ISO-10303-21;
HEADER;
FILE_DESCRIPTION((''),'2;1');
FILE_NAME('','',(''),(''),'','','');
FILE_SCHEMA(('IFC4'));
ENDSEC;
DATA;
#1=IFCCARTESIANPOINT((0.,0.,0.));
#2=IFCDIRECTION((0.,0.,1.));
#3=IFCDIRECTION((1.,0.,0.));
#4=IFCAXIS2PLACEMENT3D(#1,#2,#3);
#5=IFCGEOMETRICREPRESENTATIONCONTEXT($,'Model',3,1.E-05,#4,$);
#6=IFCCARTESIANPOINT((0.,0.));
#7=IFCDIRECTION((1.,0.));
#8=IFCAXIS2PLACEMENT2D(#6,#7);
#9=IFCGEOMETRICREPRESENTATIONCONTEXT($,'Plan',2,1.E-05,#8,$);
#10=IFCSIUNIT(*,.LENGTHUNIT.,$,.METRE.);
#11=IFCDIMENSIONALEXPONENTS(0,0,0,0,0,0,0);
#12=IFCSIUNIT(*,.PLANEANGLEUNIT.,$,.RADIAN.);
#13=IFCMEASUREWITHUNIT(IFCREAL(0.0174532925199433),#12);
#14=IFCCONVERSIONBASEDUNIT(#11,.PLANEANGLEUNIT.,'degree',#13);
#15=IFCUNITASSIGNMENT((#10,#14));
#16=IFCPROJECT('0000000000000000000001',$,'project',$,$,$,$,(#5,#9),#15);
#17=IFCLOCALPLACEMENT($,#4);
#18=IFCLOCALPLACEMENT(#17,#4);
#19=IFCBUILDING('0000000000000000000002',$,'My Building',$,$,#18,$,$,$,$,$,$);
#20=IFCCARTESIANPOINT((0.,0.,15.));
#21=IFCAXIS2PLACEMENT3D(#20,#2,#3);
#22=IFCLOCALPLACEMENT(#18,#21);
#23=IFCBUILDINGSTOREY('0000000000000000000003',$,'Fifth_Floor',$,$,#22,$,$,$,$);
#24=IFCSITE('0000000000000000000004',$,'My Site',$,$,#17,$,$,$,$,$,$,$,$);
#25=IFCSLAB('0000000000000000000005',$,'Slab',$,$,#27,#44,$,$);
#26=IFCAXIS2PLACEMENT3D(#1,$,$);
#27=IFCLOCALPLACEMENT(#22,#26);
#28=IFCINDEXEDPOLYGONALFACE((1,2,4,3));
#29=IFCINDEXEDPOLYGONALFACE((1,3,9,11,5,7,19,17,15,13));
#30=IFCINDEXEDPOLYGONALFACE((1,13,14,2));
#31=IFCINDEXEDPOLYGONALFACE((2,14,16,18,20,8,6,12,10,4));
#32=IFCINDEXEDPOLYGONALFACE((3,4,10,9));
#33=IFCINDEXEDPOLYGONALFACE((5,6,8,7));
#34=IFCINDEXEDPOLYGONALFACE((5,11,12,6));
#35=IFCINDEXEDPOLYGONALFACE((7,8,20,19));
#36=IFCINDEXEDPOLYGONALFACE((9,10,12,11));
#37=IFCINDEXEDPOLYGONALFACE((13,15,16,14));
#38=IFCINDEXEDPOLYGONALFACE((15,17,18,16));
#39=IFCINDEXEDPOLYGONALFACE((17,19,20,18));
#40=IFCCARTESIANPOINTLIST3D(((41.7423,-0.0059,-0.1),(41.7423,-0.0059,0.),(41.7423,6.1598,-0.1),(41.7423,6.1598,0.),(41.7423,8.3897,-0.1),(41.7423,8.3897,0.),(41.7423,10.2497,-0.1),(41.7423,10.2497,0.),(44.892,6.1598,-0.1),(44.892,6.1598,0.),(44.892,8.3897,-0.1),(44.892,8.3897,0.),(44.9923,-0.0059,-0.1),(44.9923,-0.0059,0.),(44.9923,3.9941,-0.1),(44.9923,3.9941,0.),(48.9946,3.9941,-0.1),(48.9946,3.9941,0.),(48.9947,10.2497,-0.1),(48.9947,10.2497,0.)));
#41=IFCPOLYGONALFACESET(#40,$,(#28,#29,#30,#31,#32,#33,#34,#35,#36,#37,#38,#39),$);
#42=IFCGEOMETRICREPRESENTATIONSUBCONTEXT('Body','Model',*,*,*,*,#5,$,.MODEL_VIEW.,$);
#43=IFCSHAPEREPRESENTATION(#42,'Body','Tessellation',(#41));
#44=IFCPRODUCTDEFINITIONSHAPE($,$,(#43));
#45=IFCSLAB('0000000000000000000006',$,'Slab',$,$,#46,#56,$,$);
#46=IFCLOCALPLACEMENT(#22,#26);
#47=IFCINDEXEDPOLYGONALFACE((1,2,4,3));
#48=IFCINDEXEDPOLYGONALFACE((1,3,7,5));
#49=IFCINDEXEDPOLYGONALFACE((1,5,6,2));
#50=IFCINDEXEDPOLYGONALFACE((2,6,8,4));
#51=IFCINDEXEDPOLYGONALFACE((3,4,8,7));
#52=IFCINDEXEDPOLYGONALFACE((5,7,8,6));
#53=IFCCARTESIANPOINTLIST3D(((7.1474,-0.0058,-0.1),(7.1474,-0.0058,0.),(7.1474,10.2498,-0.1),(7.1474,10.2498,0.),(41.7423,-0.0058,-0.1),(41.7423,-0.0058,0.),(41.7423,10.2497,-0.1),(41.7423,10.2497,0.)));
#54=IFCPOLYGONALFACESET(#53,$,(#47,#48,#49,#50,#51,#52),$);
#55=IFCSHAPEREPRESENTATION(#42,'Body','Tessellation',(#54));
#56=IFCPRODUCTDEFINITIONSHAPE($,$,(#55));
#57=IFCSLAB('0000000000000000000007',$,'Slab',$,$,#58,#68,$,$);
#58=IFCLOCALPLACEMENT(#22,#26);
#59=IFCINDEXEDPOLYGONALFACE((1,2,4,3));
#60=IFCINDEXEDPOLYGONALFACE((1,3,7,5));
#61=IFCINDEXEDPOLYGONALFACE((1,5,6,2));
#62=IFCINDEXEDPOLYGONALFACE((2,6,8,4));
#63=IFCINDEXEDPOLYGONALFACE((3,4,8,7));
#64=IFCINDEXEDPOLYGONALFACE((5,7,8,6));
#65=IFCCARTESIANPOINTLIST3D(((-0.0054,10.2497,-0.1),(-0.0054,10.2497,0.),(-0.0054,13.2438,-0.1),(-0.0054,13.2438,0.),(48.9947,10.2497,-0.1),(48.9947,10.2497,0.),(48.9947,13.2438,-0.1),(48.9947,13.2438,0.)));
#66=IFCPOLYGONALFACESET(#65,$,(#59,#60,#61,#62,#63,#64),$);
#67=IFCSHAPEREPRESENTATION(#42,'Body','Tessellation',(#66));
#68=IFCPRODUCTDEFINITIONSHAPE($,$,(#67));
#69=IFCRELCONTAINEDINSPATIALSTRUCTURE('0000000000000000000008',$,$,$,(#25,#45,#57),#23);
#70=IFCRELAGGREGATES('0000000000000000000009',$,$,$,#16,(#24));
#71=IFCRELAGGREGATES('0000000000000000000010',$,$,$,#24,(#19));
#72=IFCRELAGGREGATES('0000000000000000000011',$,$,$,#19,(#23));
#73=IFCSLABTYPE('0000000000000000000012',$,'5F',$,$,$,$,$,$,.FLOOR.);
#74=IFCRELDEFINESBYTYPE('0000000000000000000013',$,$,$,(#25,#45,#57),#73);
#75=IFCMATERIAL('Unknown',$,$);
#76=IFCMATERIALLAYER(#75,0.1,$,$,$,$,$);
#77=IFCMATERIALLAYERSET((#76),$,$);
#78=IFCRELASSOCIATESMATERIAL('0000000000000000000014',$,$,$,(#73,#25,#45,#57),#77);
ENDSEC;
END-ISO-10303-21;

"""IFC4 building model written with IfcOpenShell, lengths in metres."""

from ifc_helpers import new_model, entity, si_unit, converted_unit, frame, origin_with_axes, origin_2d_with_axis, place, context, subcontext, project, spatial, indexed_curve, outline, extrude, material, layer, layer_set, layer_usage, type_object, element, save


model = new_model("IFC4")

# Units and contexts
model_context = context("Model", 3, precision=1e-05, world=origin_with_axes())
plan_context = context("Plan", 2, precision=1e-05, world=origin_2d_with_axis())
body_context = subcontext(model_context, "Body", "Model", "MODEL_VIEW")
ifc_project = project(units=[si_unit("LENGTHUNIT", "METRE"), converted_unit("PLANEANGLEUNIT", "degree", entity("IfcReal", 0.0174532925199433), si_unit("PLANEANGLEUNIT", "RADIAN"), dimensions=[0, 0, 0, 0, 0, 0, 0])], contexts=[model_context, plan_context])

# Site, building, storey
site_placement = place(None, origin_with_axes())
site = spatial("IfcSite", under=ifc_project, at=site_placement, Name="My Site")
building_placement = place(site_placement, origin_with_axes())
building = spatial("IfcBuilding", under=site, at=building_placement, Name="My Building")
storey_placement = place(building_placement, frame((0.0, 0.0, 15.0), z_axis=(0.0, 0.0, 1.0), x_axis=(1.0, 0.0, 0.0)))
storey = spatial("IfcBuildingStorey", under=building, at=storey_placement, Name="Fifth_Floor")

# Shared definitions
ifc_material = material(Name="Unknown")

# Slabs
ifc_layer = layer(ifc_material, 0.1)
ifc_layer_set = layer_set([ifc_layer])
slab_type = type_object("IfcSlabType", Name="5F", PredefinedType="FLOOR", material=ifc_layer_set)
ifc_layer_usage_1 = layer_usage(ifc_layer_set, "AXIS3", "POSITIVE", -0.1)
slab_1_placement = place(storey_placement, frame((48.9947, 10.2497, 0.0), z_axis=(0.0, 0.0, 1.0), x_axis=(1.0, 0.0, 0.0)))
element("IfcSlab", 1, at=slab_1_placement, inside=storey, type_object=slab_type, material=ifc_layer_usage_1, Name="Slab", context=body_context, shape_type="SweptSolid", body=[
    extrude(outline(indexed_curve([(0.0, 0.0), (-7.2524, 0.0), (-7.2524, -1.86), (-4.1027, -1.86), (-4.1027, -4.09), (-7.2524, -4.09), (-7.2524, -10.2556), (-4.0024, -10.2556), (-4.0024, -6.2557), (-0.0001, -6.2557), (0.0, 0.0)])), frame((0.0, 0.0, -0.1), z_axis=(0.0, 0.0, 1.0), x_axis=(1.0, 0.0, 0.0)), (0.0, 0.0, 1.0), 0.1),
])
ifc_layer_usage_2 = layer_usage(ifc_layer_set, "AXIS3", "POSITIVE", -0.1)
slab_2_placement = place(storey_placement, frame((41.7423, 10.2497, 0.0), z_axis=(0.0, 0.0, 1.0), x_axis=(1.0, 0.0, 0.0)))
element("IfcSlab", 2, at=slab_2_placement, inside=storey, type_object=slab_type, material=ifc_layer_usage_2, Name="Slab", context=body_context, shape_type="SweptSolid", body=[
    extrude(outline(indexed_curve([(0.0, 0.0), (0.0, -10.2555), (-34.5949, -10.2555), (-34.5949, 0.0), (0.0, 0.0)])), frame((0.0, 0.0, -0.1), z_axis=(0.0, 0.0, 1.0), x_axis=(1.0, 0.0, 0.0)), (0.0, 0.0, 1.0), 0.1),
])
ifc_layer_usage_3 = layer_usage(ifc_layer_set, "AXIS3", "POSITIVE", -0.1)
slab_3_placement = place(storey_placement, frame((48.9947, 13.2438, 0.0), z_axis=(0.0, 0.0, 1.0), x_axis=(1.0, 0.0, 0.0)))
element("IfcSlab", 3, at=slab_3_placement, inside=storey, type_object=slab_type, material=ifc_layer_usage_3, Name="Slab", context=body_context, shape_type="SweptSolid", body=[
    extrude(outline(indexed_curve([(0.0, 0.0), (-49.0001, 0.0), (-49.0001, -2.994), (0.0, -2.994), (0.0, 0.0)])), frame((0.0, 0.0, -0.1), z_axis=(0.0, 0.0, 1.0), x_axis=(1.0, 0.0, 0.0)), (0.0, 0.0, 1.0), 0.1),
])

save(model, "model.ifc")
